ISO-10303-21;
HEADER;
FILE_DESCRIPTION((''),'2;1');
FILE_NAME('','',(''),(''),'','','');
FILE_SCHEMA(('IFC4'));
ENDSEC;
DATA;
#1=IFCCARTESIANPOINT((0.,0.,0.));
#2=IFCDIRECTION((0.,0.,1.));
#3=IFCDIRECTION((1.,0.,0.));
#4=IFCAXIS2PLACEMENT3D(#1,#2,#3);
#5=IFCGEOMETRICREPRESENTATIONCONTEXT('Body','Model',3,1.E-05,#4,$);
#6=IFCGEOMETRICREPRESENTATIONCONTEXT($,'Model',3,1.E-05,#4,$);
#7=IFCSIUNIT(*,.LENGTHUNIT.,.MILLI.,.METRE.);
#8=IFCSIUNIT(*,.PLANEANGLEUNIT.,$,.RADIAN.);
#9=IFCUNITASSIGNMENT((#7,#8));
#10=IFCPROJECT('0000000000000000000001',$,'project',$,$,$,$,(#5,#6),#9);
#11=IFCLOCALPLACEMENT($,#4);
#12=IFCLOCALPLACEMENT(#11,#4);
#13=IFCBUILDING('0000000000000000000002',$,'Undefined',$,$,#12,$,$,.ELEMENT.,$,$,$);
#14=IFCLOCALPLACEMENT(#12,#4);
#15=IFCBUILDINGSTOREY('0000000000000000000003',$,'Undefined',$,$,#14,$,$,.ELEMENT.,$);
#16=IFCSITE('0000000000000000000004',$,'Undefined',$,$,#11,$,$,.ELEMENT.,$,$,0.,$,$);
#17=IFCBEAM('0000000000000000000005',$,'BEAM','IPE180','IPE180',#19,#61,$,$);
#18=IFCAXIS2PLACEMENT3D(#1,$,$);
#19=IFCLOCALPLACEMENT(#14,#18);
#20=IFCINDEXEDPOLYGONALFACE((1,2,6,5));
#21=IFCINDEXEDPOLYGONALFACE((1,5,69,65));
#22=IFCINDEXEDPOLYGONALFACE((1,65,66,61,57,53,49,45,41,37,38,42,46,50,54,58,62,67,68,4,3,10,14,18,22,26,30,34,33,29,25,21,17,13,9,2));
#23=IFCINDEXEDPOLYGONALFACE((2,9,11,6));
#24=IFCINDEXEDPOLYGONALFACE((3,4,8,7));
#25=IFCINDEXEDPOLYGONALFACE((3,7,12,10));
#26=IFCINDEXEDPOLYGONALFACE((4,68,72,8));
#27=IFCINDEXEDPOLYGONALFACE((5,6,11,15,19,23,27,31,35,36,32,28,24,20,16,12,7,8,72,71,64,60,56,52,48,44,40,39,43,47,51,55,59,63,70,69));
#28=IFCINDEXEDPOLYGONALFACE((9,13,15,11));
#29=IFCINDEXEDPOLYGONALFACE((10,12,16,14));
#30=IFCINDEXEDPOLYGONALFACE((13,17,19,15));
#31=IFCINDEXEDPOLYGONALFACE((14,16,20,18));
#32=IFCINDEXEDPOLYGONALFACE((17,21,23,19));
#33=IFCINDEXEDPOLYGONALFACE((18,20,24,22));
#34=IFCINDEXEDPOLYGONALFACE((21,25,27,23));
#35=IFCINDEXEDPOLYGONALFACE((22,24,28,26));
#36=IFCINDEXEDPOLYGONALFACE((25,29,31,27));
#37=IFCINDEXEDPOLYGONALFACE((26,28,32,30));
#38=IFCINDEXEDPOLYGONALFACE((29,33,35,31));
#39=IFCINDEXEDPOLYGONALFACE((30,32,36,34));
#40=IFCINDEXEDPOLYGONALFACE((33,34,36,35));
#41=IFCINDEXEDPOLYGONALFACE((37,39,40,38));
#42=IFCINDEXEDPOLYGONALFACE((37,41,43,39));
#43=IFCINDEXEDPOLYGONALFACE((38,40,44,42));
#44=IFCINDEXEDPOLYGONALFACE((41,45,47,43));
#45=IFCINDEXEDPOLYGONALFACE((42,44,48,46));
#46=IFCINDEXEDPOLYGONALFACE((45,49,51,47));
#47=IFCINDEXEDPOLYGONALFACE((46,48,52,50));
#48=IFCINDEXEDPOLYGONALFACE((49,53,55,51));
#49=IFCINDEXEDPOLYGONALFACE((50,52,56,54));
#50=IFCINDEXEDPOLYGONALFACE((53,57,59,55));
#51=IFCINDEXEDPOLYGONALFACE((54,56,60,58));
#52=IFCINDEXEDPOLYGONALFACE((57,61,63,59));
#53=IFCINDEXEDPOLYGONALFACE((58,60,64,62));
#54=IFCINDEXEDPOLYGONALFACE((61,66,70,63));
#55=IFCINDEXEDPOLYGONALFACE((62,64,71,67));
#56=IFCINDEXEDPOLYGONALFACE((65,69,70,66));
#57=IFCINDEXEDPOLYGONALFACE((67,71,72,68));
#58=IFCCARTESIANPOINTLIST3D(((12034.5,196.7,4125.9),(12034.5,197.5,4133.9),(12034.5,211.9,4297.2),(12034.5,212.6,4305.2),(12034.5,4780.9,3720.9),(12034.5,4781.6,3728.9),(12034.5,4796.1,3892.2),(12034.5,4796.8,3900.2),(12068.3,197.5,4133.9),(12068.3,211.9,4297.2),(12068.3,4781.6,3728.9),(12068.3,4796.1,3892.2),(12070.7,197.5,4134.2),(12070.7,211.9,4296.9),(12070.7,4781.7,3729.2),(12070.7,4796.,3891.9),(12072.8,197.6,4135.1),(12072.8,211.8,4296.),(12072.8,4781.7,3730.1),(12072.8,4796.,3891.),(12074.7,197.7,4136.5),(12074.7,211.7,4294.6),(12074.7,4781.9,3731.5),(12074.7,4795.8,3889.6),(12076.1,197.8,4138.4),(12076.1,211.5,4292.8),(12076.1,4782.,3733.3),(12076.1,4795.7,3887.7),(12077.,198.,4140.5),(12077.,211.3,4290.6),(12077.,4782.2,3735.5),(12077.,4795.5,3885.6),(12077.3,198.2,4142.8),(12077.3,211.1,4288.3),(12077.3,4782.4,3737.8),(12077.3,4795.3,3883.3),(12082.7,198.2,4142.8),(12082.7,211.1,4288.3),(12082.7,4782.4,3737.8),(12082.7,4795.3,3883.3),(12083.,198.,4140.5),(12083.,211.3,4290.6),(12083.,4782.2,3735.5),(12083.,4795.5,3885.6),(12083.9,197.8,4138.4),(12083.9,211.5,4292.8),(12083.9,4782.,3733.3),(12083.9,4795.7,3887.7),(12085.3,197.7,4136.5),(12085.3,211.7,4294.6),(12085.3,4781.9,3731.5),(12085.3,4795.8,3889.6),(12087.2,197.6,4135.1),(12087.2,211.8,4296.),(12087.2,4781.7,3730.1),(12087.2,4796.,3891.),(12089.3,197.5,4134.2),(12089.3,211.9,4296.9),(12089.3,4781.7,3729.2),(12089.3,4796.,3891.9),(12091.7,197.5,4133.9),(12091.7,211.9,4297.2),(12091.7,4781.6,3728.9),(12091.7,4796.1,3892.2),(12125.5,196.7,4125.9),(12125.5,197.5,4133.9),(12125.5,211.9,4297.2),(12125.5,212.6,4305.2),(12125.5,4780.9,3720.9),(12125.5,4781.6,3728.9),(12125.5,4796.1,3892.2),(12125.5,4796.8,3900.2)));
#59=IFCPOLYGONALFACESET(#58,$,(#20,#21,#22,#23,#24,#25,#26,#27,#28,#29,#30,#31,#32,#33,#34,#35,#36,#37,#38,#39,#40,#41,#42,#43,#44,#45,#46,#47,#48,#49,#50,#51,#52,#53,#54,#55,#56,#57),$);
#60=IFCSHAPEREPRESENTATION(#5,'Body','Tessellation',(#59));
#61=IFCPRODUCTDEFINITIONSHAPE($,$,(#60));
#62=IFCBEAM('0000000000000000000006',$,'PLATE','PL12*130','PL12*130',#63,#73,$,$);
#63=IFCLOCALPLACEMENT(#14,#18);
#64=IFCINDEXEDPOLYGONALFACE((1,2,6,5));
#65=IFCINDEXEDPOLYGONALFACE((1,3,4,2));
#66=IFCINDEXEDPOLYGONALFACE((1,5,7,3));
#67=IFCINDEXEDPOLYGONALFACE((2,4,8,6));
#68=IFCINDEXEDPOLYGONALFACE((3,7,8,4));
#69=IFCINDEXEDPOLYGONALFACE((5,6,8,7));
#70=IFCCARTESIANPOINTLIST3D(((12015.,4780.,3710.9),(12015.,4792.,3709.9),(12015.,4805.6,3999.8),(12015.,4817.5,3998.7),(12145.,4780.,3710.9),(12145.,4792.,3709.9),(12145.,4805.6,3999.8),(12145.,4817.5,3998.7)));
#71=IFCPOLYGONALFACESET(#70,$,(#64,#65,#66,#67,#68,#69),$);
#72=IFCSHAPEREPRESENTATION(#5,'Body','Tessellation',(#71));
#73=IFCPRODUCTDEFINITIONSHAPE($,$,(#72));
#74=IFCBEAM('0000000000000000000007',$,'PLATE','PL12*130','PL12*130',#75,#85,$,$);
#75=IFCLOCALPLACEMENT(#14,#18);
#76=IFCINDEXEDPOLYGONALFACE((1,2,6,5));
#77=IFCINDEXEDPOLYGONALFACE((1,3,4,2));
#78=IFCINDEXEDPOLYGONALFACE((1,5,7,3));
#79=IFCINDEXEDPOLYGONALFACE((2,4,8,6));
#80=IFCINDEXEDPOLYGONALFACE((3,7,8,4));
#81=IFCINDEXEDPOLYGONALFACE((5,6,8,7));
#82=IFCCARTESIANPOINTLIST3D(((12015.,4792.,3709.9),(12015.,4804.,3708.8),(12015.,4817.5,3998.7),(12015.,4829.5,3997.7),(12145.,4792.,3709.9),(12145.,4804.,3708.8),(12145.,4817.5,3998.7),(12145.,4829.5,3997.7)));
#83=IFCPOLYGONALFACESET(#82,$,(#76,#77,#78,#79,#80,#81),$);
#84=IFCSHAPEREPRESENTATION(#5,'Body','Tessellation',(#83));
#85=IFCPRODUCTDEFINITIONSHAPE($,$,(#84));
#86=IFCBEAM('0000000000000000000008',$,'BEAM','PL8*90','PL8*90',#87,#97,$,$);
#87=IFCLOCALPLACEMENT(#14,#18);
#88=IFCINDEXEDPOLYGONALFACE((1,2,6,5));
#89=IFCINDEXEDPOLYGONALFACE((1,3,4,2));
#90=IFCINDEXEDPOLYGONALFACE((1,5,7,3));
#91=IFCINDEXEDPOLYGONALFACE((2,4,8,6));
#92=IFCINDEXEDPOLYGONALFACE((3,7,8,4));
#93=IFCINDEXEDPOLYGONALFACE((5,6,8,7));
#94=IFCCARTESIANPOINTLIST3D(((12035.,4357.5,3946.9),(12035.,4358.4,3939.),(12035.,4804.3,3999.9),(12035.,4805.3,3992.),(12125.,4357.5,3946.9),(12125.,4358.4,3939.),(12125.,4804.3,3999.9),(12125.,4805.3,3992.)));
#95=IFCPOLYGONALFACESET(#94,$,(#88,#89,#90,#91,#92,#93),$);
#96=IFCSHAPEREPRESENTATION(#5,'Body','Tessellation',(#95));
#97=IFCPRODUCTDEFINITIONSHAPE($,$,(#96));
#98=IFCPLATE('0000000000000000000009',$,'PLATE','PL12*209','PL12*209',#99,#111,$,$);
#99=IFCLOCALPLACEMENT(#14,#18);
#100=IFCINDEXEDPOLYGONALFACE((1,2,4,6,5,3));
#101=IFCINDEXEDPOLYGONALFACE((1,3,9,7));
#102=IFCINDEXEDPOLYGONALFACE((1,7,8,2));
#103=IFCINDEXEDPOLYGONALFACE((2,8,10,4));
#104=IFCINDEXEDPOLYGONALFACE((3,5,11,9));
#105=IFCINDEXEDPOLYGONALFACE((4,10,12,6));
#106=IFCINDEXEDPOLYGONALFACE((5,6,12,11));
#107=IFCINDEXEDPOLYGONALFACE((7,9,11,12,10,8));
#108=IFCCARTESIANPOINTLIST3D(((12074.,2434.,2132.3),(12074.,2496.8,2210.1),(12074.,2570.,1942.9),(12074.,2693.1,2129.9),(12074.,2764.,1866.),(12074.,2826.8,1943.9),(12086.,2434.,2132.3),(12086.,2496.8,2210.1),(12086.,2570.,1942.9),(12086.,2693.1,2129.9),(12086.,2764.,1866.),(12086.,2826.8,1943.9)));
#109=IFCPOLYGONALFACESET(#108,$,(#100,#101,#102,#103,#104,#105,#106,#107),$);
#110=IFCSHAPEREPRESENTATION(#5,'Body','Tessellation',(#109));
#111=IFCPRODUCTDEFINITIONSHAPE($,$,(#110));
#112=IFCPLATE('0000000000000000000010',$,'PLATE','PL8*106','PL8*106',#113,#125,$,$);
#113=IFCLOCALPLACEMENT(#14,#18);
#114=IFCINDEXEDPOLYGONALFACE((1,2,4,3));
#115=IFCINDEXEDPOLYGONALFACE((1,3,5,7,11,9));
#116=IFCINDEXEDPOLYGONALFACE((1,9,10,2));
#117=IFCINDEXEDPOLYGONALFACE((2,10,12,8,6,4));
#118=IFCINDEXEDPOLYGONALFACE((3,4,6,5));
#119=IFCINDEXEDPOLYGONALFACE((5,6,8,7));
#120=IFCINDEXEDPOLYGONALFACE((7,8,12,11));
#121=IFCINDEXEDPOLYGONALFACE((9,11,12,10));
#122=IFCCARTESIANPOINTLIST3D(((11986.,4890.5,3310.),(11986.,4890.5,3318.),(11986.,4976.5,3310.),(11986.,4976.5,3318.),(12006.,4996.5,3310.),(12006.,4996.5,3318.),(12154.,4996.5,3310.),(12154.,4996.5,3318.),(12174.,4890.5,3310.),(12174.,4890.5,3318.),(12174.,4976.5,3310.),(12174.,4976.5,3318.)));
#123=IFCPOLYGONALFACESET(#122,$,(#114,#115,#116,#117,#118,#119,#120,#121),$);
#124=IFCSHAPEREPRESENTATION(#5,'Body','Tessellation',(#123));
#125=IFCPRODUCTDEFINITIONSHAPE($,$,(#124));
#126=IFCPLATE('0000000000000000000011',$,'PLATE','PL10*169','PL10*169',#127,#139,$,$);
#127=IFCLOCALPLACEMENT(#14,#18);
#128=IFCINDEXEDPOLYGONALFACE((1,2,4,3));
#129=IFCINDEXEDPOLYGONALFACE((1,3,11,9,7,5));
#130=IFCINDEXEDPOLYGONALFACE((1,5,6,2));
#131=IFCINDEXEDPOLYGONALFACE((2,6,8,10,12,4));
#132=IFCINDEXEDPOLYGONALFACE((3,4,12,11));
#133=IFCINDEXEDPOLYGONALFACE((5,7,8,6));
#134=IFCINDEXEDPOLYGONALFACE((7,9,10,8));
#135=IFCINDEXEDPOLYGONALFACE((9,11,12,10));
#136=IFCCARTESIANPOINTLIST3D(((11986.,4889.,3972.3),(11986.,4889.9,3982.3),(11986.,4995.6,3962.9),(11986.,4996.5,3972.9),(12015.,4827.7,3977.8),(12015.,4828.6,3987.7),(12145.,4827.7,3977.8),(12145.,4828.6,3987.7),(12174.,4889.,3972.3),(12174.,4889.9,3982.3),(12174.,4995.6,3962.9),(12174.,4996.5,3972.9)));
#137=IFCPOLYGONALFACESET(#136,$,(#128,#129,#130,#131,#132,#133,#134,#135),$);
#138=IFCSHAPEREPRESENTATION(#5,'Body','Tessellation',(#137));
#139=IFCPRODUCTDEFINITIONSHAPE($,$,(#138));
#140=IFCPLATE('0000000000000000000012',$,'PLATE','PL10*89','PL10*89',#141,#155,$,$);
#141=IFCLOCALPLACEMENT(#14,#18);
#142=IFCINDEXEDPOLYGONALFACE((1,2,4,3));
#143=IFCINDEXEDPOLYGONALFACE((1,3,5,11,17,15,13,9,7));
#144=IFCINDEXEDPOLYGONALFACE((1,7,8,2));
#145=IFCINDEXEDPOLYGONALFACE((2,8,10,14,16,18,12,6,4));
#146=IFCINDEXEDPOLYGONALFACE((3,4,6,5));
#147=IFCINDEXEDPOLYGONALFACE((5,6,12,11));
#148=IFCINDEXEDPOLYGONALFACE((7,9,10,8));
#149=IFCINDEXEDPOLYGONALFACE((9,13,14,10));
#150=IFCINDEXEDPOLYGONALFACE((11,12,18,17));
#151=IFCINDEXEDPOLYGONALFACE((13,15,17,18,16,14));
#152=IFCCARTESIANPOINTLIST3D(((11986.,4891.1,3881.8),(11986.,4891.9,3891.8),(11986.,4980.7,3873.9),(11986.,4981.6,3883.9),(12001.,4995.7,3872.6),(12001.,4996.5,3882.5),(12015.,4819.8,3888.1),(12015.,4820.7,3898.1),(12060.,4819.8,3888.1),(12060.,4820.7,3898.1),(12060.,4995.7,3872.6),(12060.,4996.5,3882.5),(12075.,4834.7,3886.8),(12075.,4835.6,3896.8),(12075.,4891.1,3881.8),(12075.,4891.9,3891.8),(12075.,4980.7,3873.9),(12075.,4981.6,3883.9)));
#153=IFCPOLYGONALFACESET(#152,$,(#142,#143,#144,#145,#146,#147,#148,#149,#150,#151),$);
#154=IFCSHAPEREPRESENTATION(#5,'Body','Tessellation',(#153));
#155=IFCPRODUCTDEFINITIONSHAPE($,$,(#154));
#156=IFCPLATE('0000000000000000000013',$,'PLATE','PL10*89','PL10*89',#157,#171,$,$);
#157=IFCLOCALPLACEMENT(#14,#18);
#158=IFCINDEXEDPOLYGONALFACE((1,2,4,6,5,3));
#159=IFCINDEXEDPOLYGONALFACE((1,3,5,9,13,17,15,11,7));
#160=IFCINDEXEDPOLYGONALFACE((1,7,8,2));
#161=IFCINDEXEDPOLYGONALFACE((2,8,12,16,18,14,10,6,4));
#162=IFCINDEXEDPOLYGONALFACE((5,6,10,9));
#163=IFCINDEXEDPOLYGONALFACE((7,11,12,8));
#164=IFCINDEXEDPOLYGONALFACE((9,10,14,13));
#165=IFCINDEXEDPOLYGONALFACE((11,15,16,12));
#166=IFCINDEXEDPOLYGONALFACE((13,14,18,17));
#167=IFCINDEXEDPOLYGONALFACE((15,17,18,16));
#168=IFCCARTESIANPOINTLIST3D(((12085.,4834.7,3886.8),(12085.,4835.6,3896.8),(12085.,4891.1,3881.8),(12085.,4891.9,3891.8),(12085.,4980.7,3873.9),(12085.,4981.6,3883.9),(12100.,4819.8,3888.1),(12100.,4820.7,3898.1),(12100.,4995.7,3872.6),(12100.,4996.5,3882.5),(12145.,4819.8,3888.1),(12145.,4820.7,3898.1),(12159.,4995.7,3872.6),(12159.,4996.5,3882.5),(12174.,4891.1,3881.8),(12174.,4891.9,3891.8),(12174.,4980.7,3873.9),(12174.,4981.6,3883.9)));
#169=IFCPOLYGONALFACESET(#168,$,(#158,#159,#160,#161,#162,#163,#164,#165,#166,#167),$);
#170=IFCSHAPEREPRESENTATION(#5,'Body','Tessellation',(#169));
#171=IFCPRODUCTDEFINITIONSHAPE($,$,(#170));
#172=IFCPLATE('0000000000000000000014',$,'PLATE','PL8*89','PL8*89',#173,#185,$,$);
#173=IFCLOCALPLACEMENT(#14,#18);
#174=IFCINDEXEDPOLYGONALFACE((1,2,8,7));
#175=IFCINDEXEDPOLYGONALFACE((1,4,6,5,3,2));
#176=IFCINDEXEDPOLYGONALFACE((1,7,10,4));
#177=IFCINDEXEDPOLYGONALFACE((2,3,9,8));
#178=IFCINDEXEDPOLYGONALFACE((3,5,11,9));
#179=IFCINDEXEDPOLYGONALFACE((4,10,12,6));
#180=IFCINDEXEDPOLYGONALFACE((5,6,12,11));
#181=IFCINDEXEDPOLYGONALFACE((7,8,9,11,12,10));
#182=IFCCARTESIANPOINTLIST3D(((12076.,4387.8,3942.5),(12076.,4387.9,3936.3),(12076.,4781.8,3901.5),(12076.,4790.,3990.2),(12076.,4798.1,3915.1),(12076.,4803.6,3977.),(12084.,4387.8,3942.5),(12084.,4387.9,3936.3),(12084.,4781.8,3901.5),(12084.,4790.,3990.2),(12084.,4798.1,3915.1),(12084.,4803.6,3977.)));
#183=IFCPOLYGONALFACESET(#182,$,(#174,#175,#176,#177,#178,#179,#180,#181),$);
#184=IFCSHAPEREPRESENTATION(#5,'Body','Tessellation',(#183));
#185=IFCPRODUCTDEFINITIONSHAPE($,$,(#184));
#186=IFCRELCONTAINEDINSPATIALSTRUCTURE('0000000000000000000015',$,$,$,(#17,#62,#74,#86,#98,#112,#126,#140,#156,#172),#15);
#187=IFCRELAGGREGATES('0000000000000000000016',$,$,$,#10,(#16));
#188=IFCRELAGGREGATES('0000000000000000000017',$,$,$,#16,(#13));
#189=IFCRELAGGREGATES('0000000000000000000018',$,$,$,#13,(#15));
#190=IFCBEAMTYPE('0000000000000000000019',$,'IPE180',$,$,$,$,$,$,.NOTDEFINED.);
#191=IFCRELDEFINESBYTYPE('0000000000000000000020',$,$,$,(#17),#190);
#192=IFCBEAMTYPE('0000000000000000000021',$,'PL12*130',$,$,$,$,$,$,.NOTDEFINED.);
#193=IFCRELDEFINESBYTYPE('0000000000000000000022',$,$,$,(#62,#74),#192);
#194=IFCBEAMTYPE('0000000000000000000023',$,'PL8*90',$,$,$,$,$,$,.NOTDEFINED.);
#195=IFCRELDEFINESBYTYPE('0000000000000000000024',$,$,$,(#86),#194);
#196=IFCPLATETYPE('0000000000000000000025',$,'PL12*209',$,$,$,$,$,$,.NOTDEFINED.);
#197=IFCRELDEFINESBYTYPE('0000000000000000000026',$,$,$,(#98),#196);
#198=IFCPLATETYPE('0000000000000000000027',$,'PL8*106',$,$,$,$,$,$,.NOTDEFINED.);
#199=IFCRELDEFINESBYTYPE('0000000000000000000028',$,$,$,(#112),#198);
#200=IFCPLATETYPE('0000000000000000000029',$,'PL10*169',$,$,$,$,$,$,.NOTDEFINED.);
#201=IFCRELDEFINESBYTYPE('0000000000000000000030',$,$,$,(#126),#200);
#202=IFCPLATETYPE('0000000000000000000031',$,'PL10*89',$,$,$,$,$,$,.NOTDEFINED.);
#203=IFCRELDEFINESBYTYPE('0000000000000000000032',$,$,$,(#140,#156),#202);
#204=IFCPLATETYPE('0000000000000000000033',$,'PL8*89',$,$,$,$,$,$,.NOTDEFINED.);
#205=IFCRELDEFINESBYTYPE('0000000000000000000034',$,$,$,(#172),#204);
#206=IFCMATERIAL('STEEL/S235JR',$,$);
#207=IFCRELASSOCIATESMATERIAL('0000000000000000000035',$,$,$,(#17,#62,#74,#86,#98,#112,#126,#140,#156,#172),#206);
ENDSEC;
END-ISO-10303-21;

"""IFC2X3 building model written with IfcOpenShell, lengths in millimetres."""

from ifc_helpers import new_model, si_unit, frame, origin_with_axes, origin_2d_with_axis, place, context, project, spatial, polyline, rectangle, i_section, outline, extrude, material, type_object, element, save


model = new_model("IFC2X3")

# Units and contexts
model_context_1 = context("Model", 3, precision=1e-05, world=origin_with_axes(), identifier="Body")
model_context_2 = context("Model", 3, precision=1e-05, world=origin_with_axes())
ifc_project = project(units=[si_unit("LENGTHUNIT", "METRE", prefix="MILLI"), si_unit("PLANEANGLEUNIT", "RADIAN")], contexts=[model_context_1, model_context_2])

# Site, building, storey
site_placement = place(None, origin_with_axes())
site = spatial("IfcSite", under=ifc_project, at=site_placement, Name="Undefined", CompositionType="ELEMENT", RefElevation=0.0)
building_placement = place(site_placement, origin_with_axes())
building = spatial("IfcBuilding", under=site, at=building_placement, Name="Undefined", CompositionType="ELEMENT")
storey_placement = place(building_placement, origin_with_axes())
storey = spatial("IfcBuildingStorey", under=building, at=storey_placement, Name="Undefined", CompositionType="ELEMENT")

# Shared definitions
ifc_material = material(Name="STEEL/S235JR")

# Beams
beam_type_1 = type_object("IfcBeamType", Name="IPE180", PredefinedType="NOTDEFINED")
beam_1_placement = place(storey_placement, frame((12080.0, 4788.8, 3810.5), z_axis=(0.0, 0.08801, 0.99612), x_axis=(0.0, -0.99612, 0.08801)))
element("IfcBeam", 1, at=beam_1_placement, inside=storey, type_object=beam_type_1, material=ifc_material, Name="BEAM", Description="IPE180", ObjectType="IPE180", context=model_context_1, shape_type="SweptSolid", body=[
    extrude(i_section(OverallWidth=91.0, OverallDepth=180.0, WebThickness=5.3, FlangeThickness=8.0, FilletRadius=9.0, at=origin_2d_with_axis()), frame((4602.0, 0.0, 0.0), z_axis=(-1.0, 0.0, 0.0), x_axis=(0.0, -1.0, 0.0)), (0.0, 0.0, 1.0), 4602.0),
])
beam_type_2 = type_object("IfcBeamType", Name="PL12*130", PredefinedType="NOTDEFINED")
beam_2_placement = place(storey_placement, frame((12080.0, 4786.0, 3710.4), z_axis=(1.0, 0.0, 0.0), x_axis=(0.0, 0.087999, 0.996121)))
element("IfcBeam", 2, at=beam_2_placement, inside=storey, type_object=beam_type_2, material=ifc_material, Name="PLATE", Description="PL12*130", ObjectType="PL12*130", context=model_context_1, shape_type="SweptSolid", body=[
    extrude(rectangle(XDim=12.0, YDim=130.0, at=origin_2d_with_axis()), frame((290.0, 0.0, 0.0), z_axis=(-1.0, 0.0, 0.0), x_axis=(0.0, -1.0, 0.0)), (0.0, 0.0, 1.0), 290.0),
])
beam_3_placement = place(storey_placement, frame((12080.0, 4798.0, 3709.3), z_axis=(1.0, 0.0, 0.0), x_axis=(0.0, 0.087999, 0.996121)))
element("IfcBeam", 3, at=beam_3_placement, inside=storey, type_object=beam_type_2, material=ifc_material, Name="PLATE", Description="PL12*130", ObjectType="PL12*130", context=model_context_1, shape_type="SweptSolid", body=[
    extrude(rectangle(XDim=12.0, YDim=130.0, at=origin_2d_with_axis()), frame((290.0, 0.0, 0.0), z_axis=(-1.0, 0.0, 0.0), x_axis=(0.0, -1.0, 0.0)), (0.0, 0.0, 1.0), 290.0),
])
beam_type_3 = type_object("IfcBeamType", Name="PL8*90", PredefinedType="NOTDEFINED")
beam_4_placement = place(storey_placement, frame((12080.0, 4804.8, 3995.9), z_axis=(1.0, 0.0, 0.0), x_axis=(0.0, -0.993046, -0.117724)))
element("IfcBeam", 4, at=beam_4_placement, inside=storey, type_object=beam_type_3, material=ifc_material, Name="BEAM", Description="PL8*90", ObjectType="PL8*90", context=model_context_1, shape_type="SweptSolid", body=[
    extrude(rectangle(XDim=8.0, YDim=90.0, at=origin_2d_with_axis()), frame((450.0, 0.0, 0.0), z_axis=(-1.0, 0.0, 0.0), x_axis=(0.0, -1.0, 0.0)), (0.0, 0.0, 1.0), 450.0),
])

# Plates
plate_type_1 = type_object("IfcPlateType", Name="PL12*209", PredefinedType="NOTDEFINED")
plate_1_placement = place(storey_placement, frame((12080.0, 2826.8, 1943.9), z_axis=(1.0, 0.0, 0.0), x_axis=(0.0, -0.583503, 0.812111)))
element("IfcPlate", 5, at=plate_1_placement, inside=storey, type_object=plate_type_1, material=ifc_material, Name="PLATE", Description="PL12*209", ObjectType="PL12*209", context=model_context_1, shape_type="SweptSolid", body=[
    extrude(outline(polyline([(0.0, 0.0), (229.0, 0.0), (408.7, 112.6), (382.2, 209.1), (149.0, 209.1), (-26.6, 96.4), (0.0, 0.0)])), frame((0.0, 0.0, -6.0), z_axis=(0.0, 0.0, 1.0), x_axis=(1.0, 0.0, 0.0)), (0.0, 0.0, 1.0), 12.0),
])
plate_type_2 = type_object("IfcPlateType", Name="PL8*106", PredefinedType="NOTDEFINED")
plate_2_placement = place(storey_placement, frame((11986.0, 4890.5, 3314.0), z_axis=(0.0, 0.0, -1.0), x_axis=(0.0, 1.0, 0.0)))
element("IfcPlate", 6, at=plate_2_placement, inside=storey, type_object=plate_type_2, material=ifc_material, Name="PLATE", Description="PL8*106", ObjectType="PL8*106", context=model_context_1, shape_type="SweptSolid", body=[
    extrude(outline(polyline([(0.0, 0.0), (86.0, 0.0), (106.0, 20.0), (106.0, 168.0), (86.0, 188.0), (0.0, 188.0), (0.0, 0.0)])), frame((0.0, 0.0, -4.0), z_axis=(0.0, 0.0, 1.0), x_axis=(1.0, 0.0, 0.0)), (0.0, 0.0, 1.0), 8.0),
])
plate_type_3 = type_object("IfcPlateType", Name="PL10*169", PredefinedType="NOTDEFINED")
plate_3_placement = place(storey_placement, frame((12015.0, 4828.2, 3982.7), z_axis=(0.0, -0.08801, -0.99612), x_axis=(-0.426221, 0.901109, -0.079616)))
element("IfcPlate", 7, at=plate_3_placement, inside=storey, type_object=plate_type_3, material=ifc_material, Name="PLATE", Description="PL10*169", ObjectType="PL10*169", context=model_context_1, shape_type="SweptSolid", body=[
    extrude(outline(polyline([(0.0, 0.0), (68.0, 0.0), (164.8, 45.6), (84.7, 215.7), (-12.1, 170.1), (-55.4, 117.6), (0.0, 0.0)])), frame((0.0, 0.0, -5.0), z_axis=(0.0, 0.0, 1.0), x_axis=(1.0, 0.0, 0.0)), (0.0, 0.0, 1.0), 10.0),
])
plate_type_4 = type_object("IfcPlateType", Name="PL10*89", PredefinedType="NOTDEFINED")
for number, where, z_axis, x_axis, name in (
    (8, (12075.0, 4820.2, 3893.1), (0.0, 0.08801, 0.99612), (0.0, 0.99612, -0.08801), "PLATE"),
    (9, (12085.0, 4820.2, 3893.1), (0.0, -0.08801, -0.99612), (0.0, 0.99612, -0.08801), "PLATE"),
):
    element("IfcPlate", number, at=place(storey_placement, frame(where, z_axis=z_axis, x_axis=x_axis)), inside=storey, type_object=plate_type_4, material=ifc_material, Name=name, Description="PL10*89", ObjectType="PL10*89", context=model_context_1, shape_type="SweptSolid", body=[
        extrude(outline(polyline([(0.0, 15.0), (15.0, 0.0), (71.6, 0.0), (161.6, 0.0), (176.6, 15.0), (176.6, 74.0), (161.6, 89.0), (71.6, 89.0), (0.0, 60.0), (0.0, 15.0)])), frame((0.0, 0.0, -5.0), z_axis=(0.0, 0.0, 1.0), x_axis=(1.0, 0.0, 0.0)), (0.0, 0.0, 1.0), 10.0),
    ])
plate_type_5 = type_object("IfcPlateType", Name="PL8*89", PredefinedType="NOTDEFINED")
plate_4_placement = place(storey_placement, frame((12080.0, 4796.8, 3900.2), z_axis=(1.0, 0.0, 0.0), x_axis=(0.0, 0.087999, 0.996121)))
element("IfcPlate", 10, at=plate_4_placement, inside=storey, type_object=plate_type_5, material=ifc_material, Name="PLATE", Description="PL8*89", ObjectType="PL8*89", context=model_context_1, shape_type="SweptSolid", body=[
    extrude(outline(polyline([(0.0, 15.0), (15.0, 0.0), (77.1, 0.0), (89.0, 14.7), (6.1, 411.1), (0.0, 410.5), (0.0, 15.0)])), frame((0.0, 0.0, -4.0), z_axis=(0.0, 0.0, 1.0), x_axis=(1.0, 0.0, 0.0)), (0.0, 0.0, 1.0), 8.0),
])

save(model, "model.ifc")
